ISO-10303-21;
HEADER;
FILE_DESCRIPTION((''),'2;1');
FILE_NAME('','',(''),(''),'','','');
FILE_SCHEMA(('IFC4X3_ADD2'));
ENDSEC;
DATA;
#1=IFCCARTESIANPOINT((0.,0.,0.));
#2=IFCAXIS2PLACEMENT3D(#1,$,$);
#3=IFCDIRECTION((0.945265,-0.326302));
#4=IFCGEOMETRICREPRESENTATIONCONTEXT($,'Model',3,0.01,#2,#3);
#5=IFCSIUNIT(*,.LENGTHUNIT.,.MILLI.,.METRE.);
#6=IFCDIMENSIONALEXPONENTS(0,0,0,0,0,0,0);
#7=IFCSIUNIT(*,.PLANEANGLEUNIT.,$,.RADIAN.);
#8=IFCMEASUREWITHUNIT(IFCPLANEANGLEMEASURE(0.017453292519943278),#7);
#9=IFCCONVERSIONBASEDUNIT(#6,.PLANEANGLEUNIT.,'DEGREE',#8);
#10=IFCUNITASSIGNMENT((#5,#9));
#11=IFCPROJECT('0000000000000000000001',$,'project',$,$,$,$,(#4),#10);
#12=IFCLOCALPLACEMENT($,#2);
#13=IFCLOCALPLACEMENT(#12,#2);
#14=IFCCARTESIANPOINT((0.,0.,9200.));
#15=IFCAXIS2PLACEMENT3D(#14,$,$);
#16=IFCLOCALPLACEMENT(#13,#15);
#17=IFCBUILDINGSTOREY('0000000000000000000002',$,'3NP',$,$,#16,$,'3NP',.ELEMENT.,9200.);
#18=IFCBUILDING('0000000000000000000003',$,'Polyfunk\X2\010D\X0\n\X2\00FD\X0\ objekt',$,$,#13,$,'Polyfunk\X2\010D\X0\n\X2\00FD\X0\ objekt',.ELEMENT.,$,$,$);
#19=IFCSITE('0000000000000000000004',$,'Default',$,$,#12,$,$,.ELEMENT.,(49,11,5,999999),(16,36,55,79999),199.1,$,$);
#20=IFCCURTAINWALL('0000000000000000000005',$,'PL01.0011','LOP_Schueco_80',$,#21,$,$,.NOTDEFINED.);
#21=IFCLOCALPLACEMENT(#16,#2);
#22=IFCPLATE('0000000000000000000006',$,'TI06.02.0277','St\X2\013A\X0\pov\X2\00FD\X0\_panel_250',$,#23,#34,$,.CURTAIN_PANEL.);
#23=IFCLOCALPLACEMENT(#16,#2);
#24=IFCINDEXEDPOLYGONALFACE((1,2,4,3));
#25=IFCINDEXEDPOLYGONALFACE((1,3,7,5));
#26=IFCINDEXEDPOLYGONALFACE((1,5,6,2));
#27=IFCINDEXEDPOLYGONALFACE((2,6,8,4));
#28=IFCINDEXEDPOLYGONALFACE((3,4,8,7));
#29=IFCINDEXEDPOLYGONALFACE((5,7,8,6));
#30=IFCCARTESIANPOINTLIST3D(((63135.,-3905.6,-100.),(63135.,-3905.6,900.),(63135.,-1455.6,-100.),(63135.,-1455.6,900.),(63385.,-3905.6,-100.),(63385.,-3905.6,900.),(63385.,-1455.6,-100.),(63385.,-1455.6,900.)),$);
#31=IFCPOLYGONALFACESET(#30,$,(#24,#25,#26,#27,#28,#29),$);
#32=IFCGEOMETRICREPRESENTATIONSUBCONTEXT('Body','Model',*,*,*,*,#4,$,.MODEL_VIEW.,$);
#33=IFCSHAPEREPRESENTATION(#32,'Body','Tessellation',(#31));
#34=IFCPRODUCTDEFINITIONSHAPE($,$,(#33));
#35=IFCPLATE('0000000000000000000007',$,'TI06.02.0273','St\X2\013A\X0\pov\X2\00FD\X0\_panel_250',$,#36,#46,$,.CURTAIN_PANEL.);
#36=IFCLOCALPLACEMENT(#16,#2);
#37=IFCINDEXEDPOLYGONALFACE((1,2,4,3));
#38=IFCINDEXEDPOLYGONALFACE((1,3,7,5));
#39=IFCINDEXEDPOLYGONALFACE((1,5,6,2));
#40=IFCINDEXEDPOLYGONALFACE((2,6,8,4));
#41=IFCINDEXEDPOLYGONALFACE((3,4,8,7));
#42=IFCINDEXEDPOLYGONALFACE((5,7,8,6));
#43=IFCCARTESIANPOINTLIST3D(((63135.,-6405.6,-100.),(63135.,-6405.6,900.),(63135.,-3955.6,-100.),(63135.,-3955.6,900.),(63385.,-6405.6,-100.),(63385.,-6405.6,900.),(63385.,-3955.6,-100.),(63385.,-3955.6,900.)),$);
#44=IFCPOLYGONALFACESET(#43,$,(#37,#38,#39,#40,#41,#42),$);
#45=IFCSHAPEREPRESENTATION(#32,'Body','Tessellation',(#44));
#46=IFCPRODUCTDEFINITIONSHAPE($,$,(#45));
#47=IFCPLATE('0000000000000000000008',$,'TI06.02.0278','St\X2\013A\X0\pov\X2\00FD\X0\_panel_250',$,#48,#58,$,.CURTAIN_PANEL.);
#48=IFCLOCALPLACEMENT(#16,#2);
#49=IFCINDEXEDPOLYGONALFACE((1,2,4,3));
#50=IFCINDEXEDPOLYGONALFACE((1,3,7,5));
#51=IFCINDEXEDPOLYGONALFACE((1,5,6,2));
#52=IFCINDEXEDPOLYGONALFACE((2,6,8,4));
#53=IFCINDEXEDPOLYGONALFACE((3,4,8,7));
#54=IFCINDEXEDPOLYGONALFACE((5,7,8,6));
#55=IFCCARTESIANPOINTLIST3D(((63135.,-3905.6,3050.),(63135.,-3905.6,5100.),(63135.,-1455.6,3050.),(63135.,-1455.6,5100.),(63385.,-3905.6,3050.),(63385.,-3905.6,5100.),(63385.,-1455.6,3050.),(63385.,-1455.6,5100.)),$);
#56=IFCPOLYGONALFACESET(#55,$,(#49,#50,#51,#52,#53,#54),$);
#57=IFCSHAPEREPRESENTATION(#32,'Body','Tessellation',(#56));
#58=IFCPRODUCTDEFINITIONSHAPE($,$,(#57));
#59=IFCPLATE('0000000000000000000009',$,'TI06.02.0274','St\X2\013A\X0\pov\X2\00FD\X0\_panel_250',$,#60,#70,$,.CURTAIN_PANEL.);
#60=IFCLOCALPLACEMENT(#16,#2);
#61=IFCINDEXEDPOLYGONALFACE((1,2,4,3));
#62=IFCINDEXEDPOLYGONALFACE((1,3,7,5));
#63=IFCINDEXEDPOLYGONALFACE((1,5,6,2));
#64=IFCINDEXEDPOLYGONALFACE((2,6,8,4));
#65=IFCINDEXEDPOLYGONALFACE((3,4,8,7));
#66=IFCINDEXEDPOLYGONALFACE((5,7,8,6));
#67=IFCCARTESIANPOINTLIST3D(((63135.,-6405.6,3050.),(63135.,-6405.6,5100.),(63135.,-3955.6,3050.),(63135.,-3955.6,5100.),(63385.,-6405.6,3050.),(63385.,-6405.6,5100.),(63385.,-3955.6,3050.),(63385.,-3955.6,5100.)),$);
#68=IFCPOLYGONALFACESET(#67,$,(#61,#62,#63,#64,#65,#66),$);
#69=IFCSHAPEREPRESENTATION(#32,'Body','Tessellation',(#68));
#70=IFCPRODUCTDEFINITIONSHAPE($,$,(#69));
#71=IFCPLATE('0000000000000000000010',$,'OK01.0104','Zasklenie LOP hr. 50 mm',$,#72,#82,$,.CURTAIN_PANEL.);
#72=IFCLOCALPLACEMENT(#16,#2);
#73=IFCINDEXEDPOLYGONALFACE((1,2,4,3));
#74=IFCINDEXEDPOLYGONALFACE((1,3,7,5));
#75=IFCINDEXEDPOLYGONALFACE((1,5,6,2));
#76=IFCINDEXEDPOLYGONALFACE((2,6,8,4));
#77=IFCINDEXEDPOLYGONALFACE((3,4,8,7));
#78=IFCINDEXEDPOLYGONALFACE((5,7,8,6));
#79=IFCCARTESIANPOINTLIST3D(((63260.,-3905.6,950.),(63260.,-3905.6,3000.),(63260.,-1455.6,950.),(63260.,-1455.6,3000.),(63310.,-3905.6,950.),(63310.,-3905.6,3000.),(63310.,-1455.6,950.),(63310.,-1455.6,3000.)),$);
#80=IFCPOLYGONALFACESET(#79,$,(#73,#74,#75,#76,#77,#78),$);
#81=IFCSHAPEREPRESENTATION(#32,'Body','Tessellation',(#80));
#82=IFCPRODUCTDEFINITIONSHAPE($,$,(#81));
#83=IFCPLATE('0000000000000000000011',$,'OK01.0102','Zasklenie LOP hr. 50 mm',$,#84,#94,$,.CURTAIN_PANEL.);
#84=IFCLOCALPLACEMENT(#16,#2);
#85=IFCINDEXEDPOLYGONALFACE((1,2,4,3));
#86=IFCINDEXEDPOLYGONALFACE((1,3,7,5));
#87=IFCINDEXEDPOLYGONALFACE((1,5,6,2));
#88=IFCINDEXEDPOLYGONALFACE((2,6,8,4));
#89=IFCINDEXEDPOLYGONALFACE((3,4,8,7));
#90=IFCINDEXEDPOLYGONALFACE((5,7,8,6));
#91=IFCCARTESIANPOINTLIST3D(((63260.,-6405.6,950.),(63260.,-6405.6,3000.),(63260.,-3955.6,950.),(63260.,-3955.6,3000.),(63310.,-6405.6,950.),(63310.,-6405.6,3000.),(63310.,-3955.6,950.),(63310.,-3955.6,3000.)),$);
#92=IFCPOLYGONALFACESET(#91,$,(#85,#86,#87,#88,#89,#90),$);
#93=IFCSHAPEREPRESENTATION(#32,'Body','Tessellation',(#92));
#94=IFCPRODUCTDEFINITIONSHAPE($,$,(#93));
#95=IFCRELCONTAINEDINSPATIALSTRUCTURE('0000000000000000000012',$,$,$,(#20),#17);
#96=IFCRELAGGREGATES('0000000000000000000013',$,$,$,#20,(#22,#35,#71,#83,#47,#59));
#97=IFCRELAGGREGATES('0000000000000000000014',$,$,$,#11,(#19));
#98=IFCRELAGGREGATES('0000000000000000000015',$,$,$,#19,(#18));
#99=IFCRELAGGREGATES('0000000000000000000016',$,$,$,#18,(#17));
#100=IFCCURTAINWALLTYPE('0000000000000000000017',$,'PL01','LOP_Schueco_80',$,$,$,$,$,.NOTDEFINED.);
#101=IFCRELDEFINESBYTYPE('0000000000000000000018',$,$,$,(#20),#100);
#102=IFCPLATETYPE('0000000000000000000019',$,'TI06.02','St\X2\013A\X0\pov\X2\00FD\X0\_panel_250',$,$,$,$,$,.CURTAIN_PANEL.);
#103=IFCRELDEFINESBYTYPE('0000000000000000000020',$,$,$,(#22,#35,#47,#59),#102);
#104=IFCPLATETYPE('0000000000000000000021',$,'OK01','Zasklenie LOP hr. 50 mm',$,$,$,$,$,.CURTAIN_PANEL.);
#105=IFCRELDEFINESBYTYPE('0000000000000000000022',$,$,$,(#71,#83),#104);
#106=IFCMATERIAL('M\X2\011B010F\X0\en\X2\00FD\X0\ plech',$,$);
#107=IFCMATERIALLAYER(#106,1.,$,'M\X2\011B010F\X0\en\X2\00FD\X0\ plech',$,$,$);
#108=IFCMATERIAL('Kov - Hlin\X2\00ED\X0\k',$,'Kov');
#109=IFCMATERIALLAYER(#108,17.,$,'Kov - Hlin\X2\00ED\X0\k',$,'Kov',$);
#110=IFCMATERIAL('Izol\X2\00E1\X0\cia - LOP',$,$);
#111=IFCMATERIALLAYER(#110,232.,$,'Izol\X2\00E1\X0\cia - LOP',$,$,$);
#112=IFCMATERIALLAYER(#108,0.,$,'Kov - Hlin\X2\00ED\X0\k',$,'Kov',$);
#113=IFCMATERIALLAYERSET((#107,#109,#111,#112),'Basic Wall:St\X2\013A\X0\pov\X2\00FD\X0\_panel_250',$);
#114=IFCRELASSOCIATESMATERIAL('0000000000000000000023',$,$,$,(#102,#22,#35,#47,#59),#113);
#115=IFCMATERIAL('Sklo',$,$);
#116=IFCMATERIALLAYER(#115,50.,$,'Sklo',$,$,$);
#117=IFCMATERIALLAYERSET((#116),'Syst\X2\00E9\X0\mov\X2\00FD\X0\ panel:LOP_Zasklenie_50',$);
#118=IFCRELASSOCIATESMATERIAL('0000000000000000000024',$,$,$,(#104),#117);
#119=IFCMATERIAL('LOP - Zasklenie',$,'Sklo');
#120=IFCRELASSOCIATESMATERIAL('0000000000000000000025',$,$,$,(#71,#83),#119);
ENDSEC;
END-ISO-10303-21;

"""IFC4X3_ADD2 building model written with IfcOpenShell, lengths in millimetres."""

from ifc_helpers import new_model, entity, si_unit, converted_unit, direction, frame, frame_2d, origin, origin_2d_with_axis, place, context, subcontext, project, spatial, rectangle, extrude, source, transform, mapped, material, layer, layer_set, layer_usage, type_object, type_shapes, element, aggregate, save


model = new_model("IFC4X3_ADD2")

# Units and contexts
model_context = context("Model", 3, precision=0.01, world=origin(), true_north=direction((0.945265, -0.326302)))
body_context = subcontext(model_context, "Body", "Model", "MODEL_VIEW")
ifc_project = project(units=[si_unit("LENGTHUNIT", "METRE", prefix="MILLI"), converted_unit("PLANEANGLEUNIT", "DEGREE", entity("IfcPlaneAngleMeasure", 0.017453292519943278), si_unit("PLANEANGLEUNIT", "RADIAN"), dimensions=[0, 0, 0, 0, 0, 0, 0])], contexts=[model_context])

# Site, building, storey
site_placement = place(None, origin())
site = spatial("IfcSite", under=ifc_project, at=site_placement, Name="Default", CompositionType="ELEMENT", RefLatitude=(49, 11, 5, 999999), RefLongitude=(16, 36, 55, 79999), RefElevation=199.1)
building_placement = place(site_placement, origin())
building = spatial("IfcBuilding", under=site, at=building_placement, Name="Polyfunkčný objekt", LongName="Polyfunkčný objekt", CompositionType="ELEMENT")
storey_placement = place(building_placement, frame((0.0, 0.0, 9200.0)))
storey = spatial("IfcBuildingStorey", under=building, at=storey_placement, Name="3NP", LongName="3NP", CompositionType="ELEMENT", Elevation=9200.0)

# Curtain wall, plates
curtain_wall_type = type_object("IfcCurtainWallType", Name="PL01", Description="LOP_Schueco_80", PredefinedType="NOTDEFINED")
curtain_wall_placement = place(storey_placement, frame((0.0, 0.0, -9200.0)))
curtain_wall = element("IfcCurtainWall", 1, at=curtain_wall_placement, inside=storey, type_object=curtain_wall_type, Name="PL01.0011", Description="LOP_Schueco_80", PredefinedType="NOTDEFINED")
ifc_material_1 = material(Name="Měďený plech")
ifc_layer_1 = layer(ifc_material_1, 1.0, Name="Měďený plech")
ifc_material_2 = material(Name="Kov - Hliník", Category="Kov")
ifc_layer_2 = layer(ifc_material_2, 17.0, Name="Kov - Hliník", Category="Kov")
ifc_material_3 = material(Name="Izolácia - LOP")
ifc_layer_3 = layer(ifc_material_3, 232.0, Name="Izolácia - LOP")
ifc_layer_4 = layer(ifc_material_2, 0.0, Name="Kov - Hliník", Category="Kov")
ifc_layer_set_1 = layer_set([ifc_layer_1, ifc_layer_2, ifc_layer_3, ifc_layer_4], Name="Basic Wall:Stĺpový_panel_250")
ifc_layer_usage_1 = layer_usage(ifc_layer_set_1, "AXIS2", "NEGATIVE", 125.0)
plate_type_1 = type_object("IfcPlateType", Name="TI06.02", Description="Stĺpový_panel_250", PredefinedType="CURTAIN_PANEL", material=ifc_layer_set_1)
plate_1_placement = place(storey_placement, frame((63260.0, -1455.6, -100.0), z_axis=(0.0, 0.0, 1.0), x_axis=(0.0, -1.0, 0.0)))
plate_1 = element("IfcPlate", 2, at=plate_1_placement, type_object=plate_type_1, material=ifc_layer_usage_1, Name="TI06.02.0277", Description="Stĺpový_panel_250", PredefinedType="CURTAIN_PANEL", context=body_context, shape_type="SweptSolid", body=[
    extrude(rectangle(XDim=250.0, YDim=2450.0, at=frame_2d((0.0, 0.0), x_axis=(1.0, 0.0))), frame((1225.0, 0.0, 0.0), z_axis=(0.0, 0.0, 1.0), x_axis=(0.0, 1.0, 0.0)), (0.0, 0.0, 1.0), 1000.0),
])
ifc_layer_usage_2 = layer_usage(ifc_layer_set_1, "AXIS2", "NEGATIVE", 125.0)
plate_2_placement = place(storey_placement, frame((63260.0, -3955.6, -100.0), z_axis=(0.0, 0.0, 1.0), x_axis=(0.0, -1.0, 0.0)))
plate_2 = element("IfcPlate", 3, at=plate_2_placement, type_object=plate_type_1, material=ifc_layer_usage_2, Name="TI06.02.0273", Description="Stĺpový_panel_250", PredefinedType="CURTAIN_PANEL", context=body_context, shape_type="SweptSolid", body=[
    extrude(rectangle(XDim=250.0, YDim=2450.0, at=frame_2d((0.0, 0.0), x_axis=(1.0, 0.0))), frame((1225.0, 0.0, 0.0), z_axis=(0.0, 0.0, 1.0), x_axis=(0.0, 1.0, 0.0)), (0.0, 0.0, 1.0), 1000.0),
])
ifc_layer_usage_3 = layer_usage(ifc_layer_set_1, "AXIS2", "NEGATIVE", 125.0)
plate_3_placement = place(storey_placement, frame((63260.0, -1455.6, 3050.0), z_axis=(0.0, 0.0, 1.0), x_axis=(0.0, -1.0, 0.0)))
plate_3 = element("IfcPlate", 4, at=plate_3_placement, type_object=plate_type_1, material=ifc_layer_usage_3, Name="TI06.02.0278", Description="Stĺpový_panel_250", PredefinedType="CURTAIN_PANEL", context=body_context, shape_type="SweptSolid", body=[
    extrude(rectangle(XDim=250.0, YDim=2450.0, at=frame_2d((0.0, 0.0), x_axis=(1.0, 0.0))), frame((1225.0, 0.0, 0.0), z_axis=(0.0, 0.0, 1.0), x_axis=(0.0, 1.0, 0.0)), (0.0, 0.0, 1.0), 2050.0),
])
ifc_layer_usage_4 = layer_usage(ifc_layer_set_1, "AXIS2", "NEGATIVE", 125.0)
plate_4_placement = place(storey_placement, frame((63260.0, -3955.6, 3050.0), z_axis=(0.0, 0.0, 1.0), x_axis=(0.0, -1.0, 0.0)))
plate_4 = element("IfcPlate", 5, at=plate_4_placement, type_object=plate_type_1, material=ifc_layer_usage_4, Name="TI06.02.0274", Description="Stĺpový_panel_250", PredefinedType="CURTAIN_PANEL", context=body_context, shape_type="SweptSolid", body=[
    extrude(rectangle(XDim=250.0, YDim=2450.0, at=frame_2d((0.0, 0.0), x_axis=(1.0, 0.0))), frame((1225.0, 0.0, 0.0), z_axis=(0.0, 0.0, 1.0), x_axis=(0.0, 1.0, 0.0)), (0.0, 0.0, 1.0), 2050.0),
])
ifc_material_4 = material(Name="LOP - Zasklenie", Category="Sklo")
ifc_material_5 = material(Name="Sklo")
ifc_layer_5 = layer(ifc_material_5, 50.0, Name="Sklo")
ifc_layer_set_2 = layer_set([ifc_layer_5], Name="Systémový panel:LOP_Zasklenie_50")
plate_type_2 = type_object("IfcPlateType", Name="OK01", Description="Zasklenie LOP hr. 50 mm", PredefinedType="CURTAIN_PANEL", material=ifc_layer_set_2)
shared_shape_1 = source(origin(), body_context, "Body", "SweptSolid", [
    extrude(rectangle(XDim=50.0, YDim=2450.0, at=origin_2d_with_axis()), frame((0.0, 25.0, 0.0), z_axis=(0.0, 0.0, 1.0), x_axis=(0.0, 1.0, 0.0)), (0.0, 0.0, 1.0), 2050.0),
])
type_shapes(plate_type_2, [shared_shape_1])
plate_5_placement = place(curtain_wall_placement, frame((63260.0, -2680.6, 10150.0), z_axis=(0.0, 0.0, 1.0), x_axis=(0.0, -1.0, 0.0)))
plate_5 = element("IfcPlate", 6, at=plate_5_placement, type_object=plate_type_2, material=ifc_material_4, Name="OK01.0104", Description="Zasklenie LOP hr. 50 mm", PredefinedType="CURTAIN_PANEL", context=body_context, shape_type="MappedRepresentation", body=[
    mapped(shared_shape_1, transform((0.0, 0.0, 0.0), scale=1.0)),
])
plate_6_placement = place(curtain_wall_placement, frame((63260.0, -5180.6, 10150.0), z_axis=(0.0, 0.0, 1.0), x_axis=(0.0, -1.0, 0.0)))
plate_6 = element("IfcPlate", 7, at=plate_6_placement, type_object=plate_type_2, material=ifc_material_4, Name="OK01.0102", Description="Zasklenie LOP hr. 50 mm", PredefinedType="CURTAIN_PANEL", context=body_context, shape_type="MappedRepresentation", body=[
    mapped(shared_shape_1, transform((0.0, 0.0, 0.0), scale=1.0)),
])
aggregate(curtain_wall, [plate_1, plate_2, plate_5, plate_6, plate_3, plate_4])

save(model, "model.ifc")
